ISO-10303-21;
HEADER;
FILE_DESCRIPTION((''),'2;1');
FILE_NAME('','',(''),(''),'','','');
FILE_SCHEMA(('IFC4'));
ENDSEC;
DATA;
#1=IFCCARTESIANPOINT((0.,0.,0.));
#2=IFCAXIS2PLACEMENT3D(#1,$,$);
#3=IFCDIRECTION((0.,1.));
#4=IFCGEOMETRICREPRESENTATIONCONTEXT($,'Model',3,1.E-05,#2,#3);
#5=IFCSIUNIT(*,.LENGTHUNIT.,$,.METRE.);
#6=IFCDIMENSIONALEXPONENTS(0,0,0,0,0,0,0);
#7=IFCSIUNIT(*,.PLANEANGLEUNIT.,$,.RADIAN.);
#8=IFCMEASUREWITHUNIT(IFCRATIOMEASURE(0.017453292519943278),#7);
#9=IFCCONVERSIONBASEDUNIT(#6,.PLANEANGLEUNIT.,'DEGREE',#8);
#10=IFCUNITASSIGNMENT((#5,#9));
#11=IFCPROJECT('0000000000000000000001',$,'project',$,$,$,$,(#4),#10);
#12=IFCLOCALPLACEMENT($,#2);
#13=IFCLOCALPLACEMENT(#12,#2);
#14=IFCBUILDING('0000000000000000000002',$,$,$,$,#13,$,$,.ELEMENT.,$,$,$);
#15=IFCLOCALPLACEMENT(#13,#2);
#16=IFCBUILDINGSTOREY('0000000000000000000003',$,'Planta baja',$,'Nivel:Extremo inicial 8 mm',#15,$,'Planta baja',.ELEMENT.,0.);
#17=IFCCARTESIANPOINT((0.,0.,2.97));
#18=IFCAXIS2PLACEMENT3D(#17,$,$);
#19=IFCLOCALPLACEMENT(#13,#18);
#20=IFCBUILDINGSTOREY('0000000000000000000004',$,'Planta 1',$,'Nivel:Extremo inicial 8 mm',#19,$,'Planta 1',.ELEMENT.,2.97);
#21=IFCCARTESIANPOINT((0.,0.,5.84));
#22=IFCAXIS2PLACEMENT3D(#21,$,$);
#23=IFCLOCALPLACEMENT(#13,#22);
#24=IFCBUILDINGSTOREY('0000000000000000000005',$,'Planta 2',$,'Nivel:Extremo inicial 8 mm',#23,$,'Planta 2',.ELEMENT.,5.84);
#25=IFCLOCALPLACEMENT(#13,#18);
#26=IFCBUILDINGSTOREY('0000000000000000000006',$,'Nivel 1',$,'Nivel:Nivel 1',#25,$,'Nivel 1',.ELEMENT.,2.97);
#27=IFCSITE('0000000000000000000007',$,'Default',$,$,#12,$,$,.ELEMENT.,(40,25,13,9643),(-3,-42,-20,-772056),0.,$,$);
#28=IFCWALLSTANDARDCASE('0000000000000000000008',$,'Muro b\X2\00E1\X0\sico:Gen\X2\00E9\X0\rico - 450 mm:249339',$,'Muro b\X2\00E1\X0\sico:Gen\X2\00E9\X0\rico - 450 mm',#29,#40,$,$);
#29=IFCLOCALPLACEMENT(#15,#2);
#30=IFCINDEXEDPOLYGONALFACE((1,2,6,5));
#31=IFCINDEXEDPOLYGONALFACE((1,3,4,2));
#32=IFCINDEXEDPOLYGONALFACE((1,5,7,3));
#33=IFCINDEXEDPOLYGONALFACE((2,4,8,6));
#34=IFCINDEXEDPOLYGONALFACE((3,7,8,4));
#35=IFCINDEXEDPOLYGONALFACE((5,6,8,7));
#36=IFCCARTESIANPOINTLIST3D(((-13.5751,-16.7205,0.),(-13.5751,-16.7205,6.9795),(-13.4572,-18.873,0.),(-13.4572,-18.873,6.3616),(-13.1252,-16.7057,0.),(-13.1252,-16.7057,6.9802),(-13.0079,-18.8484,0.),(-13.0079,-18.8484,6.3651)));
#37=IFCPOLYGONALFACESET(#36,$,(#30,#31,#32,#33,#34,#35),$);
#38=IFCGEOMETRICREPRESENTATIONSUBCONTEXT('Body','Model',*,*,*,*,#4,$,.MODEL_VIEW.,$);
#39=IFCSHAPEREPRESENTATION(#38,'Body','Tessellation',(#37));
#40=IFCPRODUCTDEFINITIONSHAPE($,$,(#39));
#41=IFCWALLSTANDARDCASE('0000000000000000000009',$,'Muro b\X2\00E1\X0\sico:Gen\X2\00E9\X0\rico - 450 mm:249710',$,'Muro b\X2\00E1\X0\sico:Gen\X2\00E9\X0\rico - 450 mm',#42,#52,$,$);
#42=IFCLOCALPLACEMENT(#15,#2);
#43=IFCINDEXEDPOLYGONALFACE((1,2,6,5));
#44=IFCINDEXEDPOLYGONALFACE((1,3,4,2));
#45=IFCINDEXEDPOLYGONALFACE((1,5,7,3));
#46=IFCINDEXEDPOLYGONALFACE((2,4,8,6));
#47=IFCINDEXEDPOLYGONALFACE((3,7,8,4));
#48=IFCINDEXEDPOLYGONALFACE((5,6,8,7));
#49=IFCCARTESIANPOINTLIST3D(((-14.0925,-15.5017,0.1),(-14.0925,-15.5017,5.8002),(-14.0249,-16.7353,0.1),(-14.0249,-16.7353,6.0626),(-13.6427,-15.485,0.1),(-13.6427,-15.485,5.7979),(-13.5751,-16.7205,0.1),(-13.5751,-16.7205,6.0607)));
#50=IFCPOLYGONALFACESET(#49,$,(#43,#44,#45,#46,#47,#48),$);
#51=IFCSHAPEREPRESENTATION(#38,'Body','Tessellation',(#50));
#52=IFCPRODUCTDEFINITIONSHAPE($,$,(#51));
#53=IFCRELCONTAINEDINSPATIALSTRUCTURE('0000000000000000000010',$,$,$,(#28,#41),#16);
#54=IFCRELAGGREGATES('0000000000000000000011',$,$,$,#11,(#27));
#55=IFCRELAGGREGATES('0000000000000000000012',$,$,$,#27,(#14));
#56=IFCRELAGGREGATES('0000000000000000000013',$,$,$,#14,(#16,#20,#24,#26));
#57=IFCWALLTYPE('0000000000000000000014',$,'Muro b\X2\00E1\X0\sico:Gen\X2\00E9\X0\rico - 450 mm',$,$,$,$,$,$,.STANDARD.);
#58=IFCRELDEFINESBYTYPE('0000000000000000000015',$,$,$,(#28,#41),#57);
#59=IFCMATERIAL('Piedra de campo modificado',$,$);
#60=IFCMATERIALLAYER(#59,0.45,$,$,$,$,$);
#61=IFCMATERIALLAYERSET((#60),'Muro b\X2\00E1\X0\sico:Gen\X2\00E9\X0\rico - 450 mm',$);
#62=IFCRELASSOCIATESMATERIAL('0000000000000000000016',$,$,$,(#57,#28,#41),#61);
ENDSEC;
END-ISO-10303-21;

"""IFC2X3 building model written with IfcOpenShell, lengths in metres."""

from ifc_helpers import new_model, entity, si_unit, converted_unit, direction, frame, origin, place, context, subcontext, project, spatial, polyline, outline, extrude, clip, bounded_halfspace, material, layer, layer_set, layer_usage, type_object, element, save


model = new_model("IFC2X3")

# Units and contexts
model_context = context("Model", 3, precision=1e-05, world=origin(), true_north=direction((0.0, 1.0)))
body_context = subcontext(model_context, "Body", "Model", "MODEL_VIEW")
ifc_project = project(units=[si_unit("LENGTHUNIT", "METRE"), converted_unit("PLANEANGLEUNIT", "DEGREE", entity("IfcRatioMeasure", 0.017453292519943278), si_unit("PLANEANGLEUNIT", "RADIAN"), dimensions=[0, 0, 0, 0, 0, 0, 0])], contexts=[model_context])

# Site, building, storey
site_placement = place(None, origin())
site = spatial("IfcSite", under=ifc_project, at=site_placement, Name="Default", CompositionType="ELEMENT", RefLatitude=(40, 25, 13, 9643), RefLongitude=(-3, -42, -20, -772056), RefElevation=0.0)
building_placement = place(site_placement, origin())
building = spatial("IfcBuilding", under=site, at=building_placement, CompositionType="ELEMENT")
storey_1_placement = place(building_placement, origin())
storey_1 = spatial("IfcBuildingStorey", under=building, at=storey_1_placement, Name="Planta baja", ObjectType="Nivel:Extremo inicial 8 mm", LongName="Planta baja", CompositionType="ELEMENT", Elevation=0.0)

# Shared definitions
ifc_material_1 = material(Name="Piedra de campo modificado")

# Shared definitions
ifc_layer_1 = layer(ifc_material_1, 0.45)
ifc_layer_set_1 = layer_set([ifc_layer_1], Name="Muro básico:Genérico - 450 mm")
ifc_layer_usage_1 = layer_usage(ifc_layer_set_1, "AXIS2", "NEGATIVE", 0.225)
wall_type_1 = type_object("IfcWallType", Name="Muro básico:Genérico - 450 mm", PredefinedType="STANDARD", material=ifc_layer_set_1)

# Shared definitions
storey_2_placement = place(building_placement, frame((0.0, 0.0, 2.97)))
storey_2 = spatial("IfcBuildingStorey", under=building, at=storey_2_placement, Name="Planta 1", ObjectType="Nivel:Extremo inicial 8 mm", LongName="Planta 1", CompositionType="ELEMENT", Elevation=2.97)

# Shared definitions
storey_3_placement = place(building_placement, frame((0.0, 0.0, 5.84)))
storey_3 = spatial("IfcBuildingStorey", under=building, at=storey_3_placement, Name="Planta 2", ObjectType="Nivel:Extremo inicial 8 mm", LongName="Planta 2", CompositionType="ELEMENT", Elevation=5.84)

# Walls
wall_1_placement = place(storey_1_placement, frame((-13.3504, -16.7082, 0.0), z_axis=(0.0, 0.0, 1.0), x_axis=(0.054661, -0.998505, 0.0)))
element("IfcWallStandardCase", 1, at=wall_1_placement, inside=storey_1, type_object=wall_type_1, material=ifc_layer_usage_1, Name="Muro básico:Genérico - 450 mm:249339", ObjectType="Muro básico:Genérico - 450 mm", context=body_context, shape_type="Clipping", body=[
    clip(extrude(outline(polyline([(2.1557, -0.225), (2.1557, 0.225), (0.0098, 0.225), (0.0, -0.225), (2.1557, -0.225)])), origin(), (0.0, 0.0, 1.0), 6.9802), bounded_halfspace(frame((0.0, -0.225, 6.9795), z_axis=(0.275536, -0.007488, 0.961262), x_axis=(0.027168, 0.999631, 0.0)), False, frame((0.0, -0.225, 6.9795)), polyline([(0.0, 0.0), (2.1557, 0.0), (2.1557, 0.45), (0.0098, 0.45), (0.0, 0.0)]))),
])
wall_2_placement = place(storey_1_placement, frame((-13.7997, -16.7328, 0.1), z_axis=(0.0, 0.0, 1.0), x_axis=(-0.054661, 0.998505, 0.0)))
element("IfcWallStandardCase", 2, at=wall_2_placement, inside=storey_1, type_object=wall_type_1, material=ifc_layer_usage_1, Name="Muro básico:Genérico - 450 mm:249710", ObjectType="Muro básico:Genérico - 450 mm", context=body_context, shape_type="Clipping", body=[
    clip(extrude(outline(polyline([(1.2373, -0.225), (1.2452, 0.225), (0.0098, 0.225), (0.0, -0.225), (1.2373, -0.225)])), origin(), (0.0, 0.0, 1.0), 5.9626), bounded_halfspace(frame((0.0, -0.225, 5.9607), z_axis=(0.207732, -0.008646, 0.978148), x_axis=(0.041585, 0.999135, 0.0)), False, frame((0.0, -0.225, 5.9607)), polyline([(0.0, 0.0), (1.2373, 0.0), (1.2452, 0.45), (0.0098, 0.45), (0.0, 0.0)]))),
])

# Shared definitions
storey_4_placement = place(building_placement, frame((0.0, 0.0, 2.97)))
storey_4 = spatial("IfcBuildingStorey", under=building, at=storey_4_placement, Name="Nivel 1", ObjectType="Nivel:Nivel 1", LongName="Nivel 1", CompositionType="ELEMENT", Elevation=2.97)

save(model, "model.ifc")
